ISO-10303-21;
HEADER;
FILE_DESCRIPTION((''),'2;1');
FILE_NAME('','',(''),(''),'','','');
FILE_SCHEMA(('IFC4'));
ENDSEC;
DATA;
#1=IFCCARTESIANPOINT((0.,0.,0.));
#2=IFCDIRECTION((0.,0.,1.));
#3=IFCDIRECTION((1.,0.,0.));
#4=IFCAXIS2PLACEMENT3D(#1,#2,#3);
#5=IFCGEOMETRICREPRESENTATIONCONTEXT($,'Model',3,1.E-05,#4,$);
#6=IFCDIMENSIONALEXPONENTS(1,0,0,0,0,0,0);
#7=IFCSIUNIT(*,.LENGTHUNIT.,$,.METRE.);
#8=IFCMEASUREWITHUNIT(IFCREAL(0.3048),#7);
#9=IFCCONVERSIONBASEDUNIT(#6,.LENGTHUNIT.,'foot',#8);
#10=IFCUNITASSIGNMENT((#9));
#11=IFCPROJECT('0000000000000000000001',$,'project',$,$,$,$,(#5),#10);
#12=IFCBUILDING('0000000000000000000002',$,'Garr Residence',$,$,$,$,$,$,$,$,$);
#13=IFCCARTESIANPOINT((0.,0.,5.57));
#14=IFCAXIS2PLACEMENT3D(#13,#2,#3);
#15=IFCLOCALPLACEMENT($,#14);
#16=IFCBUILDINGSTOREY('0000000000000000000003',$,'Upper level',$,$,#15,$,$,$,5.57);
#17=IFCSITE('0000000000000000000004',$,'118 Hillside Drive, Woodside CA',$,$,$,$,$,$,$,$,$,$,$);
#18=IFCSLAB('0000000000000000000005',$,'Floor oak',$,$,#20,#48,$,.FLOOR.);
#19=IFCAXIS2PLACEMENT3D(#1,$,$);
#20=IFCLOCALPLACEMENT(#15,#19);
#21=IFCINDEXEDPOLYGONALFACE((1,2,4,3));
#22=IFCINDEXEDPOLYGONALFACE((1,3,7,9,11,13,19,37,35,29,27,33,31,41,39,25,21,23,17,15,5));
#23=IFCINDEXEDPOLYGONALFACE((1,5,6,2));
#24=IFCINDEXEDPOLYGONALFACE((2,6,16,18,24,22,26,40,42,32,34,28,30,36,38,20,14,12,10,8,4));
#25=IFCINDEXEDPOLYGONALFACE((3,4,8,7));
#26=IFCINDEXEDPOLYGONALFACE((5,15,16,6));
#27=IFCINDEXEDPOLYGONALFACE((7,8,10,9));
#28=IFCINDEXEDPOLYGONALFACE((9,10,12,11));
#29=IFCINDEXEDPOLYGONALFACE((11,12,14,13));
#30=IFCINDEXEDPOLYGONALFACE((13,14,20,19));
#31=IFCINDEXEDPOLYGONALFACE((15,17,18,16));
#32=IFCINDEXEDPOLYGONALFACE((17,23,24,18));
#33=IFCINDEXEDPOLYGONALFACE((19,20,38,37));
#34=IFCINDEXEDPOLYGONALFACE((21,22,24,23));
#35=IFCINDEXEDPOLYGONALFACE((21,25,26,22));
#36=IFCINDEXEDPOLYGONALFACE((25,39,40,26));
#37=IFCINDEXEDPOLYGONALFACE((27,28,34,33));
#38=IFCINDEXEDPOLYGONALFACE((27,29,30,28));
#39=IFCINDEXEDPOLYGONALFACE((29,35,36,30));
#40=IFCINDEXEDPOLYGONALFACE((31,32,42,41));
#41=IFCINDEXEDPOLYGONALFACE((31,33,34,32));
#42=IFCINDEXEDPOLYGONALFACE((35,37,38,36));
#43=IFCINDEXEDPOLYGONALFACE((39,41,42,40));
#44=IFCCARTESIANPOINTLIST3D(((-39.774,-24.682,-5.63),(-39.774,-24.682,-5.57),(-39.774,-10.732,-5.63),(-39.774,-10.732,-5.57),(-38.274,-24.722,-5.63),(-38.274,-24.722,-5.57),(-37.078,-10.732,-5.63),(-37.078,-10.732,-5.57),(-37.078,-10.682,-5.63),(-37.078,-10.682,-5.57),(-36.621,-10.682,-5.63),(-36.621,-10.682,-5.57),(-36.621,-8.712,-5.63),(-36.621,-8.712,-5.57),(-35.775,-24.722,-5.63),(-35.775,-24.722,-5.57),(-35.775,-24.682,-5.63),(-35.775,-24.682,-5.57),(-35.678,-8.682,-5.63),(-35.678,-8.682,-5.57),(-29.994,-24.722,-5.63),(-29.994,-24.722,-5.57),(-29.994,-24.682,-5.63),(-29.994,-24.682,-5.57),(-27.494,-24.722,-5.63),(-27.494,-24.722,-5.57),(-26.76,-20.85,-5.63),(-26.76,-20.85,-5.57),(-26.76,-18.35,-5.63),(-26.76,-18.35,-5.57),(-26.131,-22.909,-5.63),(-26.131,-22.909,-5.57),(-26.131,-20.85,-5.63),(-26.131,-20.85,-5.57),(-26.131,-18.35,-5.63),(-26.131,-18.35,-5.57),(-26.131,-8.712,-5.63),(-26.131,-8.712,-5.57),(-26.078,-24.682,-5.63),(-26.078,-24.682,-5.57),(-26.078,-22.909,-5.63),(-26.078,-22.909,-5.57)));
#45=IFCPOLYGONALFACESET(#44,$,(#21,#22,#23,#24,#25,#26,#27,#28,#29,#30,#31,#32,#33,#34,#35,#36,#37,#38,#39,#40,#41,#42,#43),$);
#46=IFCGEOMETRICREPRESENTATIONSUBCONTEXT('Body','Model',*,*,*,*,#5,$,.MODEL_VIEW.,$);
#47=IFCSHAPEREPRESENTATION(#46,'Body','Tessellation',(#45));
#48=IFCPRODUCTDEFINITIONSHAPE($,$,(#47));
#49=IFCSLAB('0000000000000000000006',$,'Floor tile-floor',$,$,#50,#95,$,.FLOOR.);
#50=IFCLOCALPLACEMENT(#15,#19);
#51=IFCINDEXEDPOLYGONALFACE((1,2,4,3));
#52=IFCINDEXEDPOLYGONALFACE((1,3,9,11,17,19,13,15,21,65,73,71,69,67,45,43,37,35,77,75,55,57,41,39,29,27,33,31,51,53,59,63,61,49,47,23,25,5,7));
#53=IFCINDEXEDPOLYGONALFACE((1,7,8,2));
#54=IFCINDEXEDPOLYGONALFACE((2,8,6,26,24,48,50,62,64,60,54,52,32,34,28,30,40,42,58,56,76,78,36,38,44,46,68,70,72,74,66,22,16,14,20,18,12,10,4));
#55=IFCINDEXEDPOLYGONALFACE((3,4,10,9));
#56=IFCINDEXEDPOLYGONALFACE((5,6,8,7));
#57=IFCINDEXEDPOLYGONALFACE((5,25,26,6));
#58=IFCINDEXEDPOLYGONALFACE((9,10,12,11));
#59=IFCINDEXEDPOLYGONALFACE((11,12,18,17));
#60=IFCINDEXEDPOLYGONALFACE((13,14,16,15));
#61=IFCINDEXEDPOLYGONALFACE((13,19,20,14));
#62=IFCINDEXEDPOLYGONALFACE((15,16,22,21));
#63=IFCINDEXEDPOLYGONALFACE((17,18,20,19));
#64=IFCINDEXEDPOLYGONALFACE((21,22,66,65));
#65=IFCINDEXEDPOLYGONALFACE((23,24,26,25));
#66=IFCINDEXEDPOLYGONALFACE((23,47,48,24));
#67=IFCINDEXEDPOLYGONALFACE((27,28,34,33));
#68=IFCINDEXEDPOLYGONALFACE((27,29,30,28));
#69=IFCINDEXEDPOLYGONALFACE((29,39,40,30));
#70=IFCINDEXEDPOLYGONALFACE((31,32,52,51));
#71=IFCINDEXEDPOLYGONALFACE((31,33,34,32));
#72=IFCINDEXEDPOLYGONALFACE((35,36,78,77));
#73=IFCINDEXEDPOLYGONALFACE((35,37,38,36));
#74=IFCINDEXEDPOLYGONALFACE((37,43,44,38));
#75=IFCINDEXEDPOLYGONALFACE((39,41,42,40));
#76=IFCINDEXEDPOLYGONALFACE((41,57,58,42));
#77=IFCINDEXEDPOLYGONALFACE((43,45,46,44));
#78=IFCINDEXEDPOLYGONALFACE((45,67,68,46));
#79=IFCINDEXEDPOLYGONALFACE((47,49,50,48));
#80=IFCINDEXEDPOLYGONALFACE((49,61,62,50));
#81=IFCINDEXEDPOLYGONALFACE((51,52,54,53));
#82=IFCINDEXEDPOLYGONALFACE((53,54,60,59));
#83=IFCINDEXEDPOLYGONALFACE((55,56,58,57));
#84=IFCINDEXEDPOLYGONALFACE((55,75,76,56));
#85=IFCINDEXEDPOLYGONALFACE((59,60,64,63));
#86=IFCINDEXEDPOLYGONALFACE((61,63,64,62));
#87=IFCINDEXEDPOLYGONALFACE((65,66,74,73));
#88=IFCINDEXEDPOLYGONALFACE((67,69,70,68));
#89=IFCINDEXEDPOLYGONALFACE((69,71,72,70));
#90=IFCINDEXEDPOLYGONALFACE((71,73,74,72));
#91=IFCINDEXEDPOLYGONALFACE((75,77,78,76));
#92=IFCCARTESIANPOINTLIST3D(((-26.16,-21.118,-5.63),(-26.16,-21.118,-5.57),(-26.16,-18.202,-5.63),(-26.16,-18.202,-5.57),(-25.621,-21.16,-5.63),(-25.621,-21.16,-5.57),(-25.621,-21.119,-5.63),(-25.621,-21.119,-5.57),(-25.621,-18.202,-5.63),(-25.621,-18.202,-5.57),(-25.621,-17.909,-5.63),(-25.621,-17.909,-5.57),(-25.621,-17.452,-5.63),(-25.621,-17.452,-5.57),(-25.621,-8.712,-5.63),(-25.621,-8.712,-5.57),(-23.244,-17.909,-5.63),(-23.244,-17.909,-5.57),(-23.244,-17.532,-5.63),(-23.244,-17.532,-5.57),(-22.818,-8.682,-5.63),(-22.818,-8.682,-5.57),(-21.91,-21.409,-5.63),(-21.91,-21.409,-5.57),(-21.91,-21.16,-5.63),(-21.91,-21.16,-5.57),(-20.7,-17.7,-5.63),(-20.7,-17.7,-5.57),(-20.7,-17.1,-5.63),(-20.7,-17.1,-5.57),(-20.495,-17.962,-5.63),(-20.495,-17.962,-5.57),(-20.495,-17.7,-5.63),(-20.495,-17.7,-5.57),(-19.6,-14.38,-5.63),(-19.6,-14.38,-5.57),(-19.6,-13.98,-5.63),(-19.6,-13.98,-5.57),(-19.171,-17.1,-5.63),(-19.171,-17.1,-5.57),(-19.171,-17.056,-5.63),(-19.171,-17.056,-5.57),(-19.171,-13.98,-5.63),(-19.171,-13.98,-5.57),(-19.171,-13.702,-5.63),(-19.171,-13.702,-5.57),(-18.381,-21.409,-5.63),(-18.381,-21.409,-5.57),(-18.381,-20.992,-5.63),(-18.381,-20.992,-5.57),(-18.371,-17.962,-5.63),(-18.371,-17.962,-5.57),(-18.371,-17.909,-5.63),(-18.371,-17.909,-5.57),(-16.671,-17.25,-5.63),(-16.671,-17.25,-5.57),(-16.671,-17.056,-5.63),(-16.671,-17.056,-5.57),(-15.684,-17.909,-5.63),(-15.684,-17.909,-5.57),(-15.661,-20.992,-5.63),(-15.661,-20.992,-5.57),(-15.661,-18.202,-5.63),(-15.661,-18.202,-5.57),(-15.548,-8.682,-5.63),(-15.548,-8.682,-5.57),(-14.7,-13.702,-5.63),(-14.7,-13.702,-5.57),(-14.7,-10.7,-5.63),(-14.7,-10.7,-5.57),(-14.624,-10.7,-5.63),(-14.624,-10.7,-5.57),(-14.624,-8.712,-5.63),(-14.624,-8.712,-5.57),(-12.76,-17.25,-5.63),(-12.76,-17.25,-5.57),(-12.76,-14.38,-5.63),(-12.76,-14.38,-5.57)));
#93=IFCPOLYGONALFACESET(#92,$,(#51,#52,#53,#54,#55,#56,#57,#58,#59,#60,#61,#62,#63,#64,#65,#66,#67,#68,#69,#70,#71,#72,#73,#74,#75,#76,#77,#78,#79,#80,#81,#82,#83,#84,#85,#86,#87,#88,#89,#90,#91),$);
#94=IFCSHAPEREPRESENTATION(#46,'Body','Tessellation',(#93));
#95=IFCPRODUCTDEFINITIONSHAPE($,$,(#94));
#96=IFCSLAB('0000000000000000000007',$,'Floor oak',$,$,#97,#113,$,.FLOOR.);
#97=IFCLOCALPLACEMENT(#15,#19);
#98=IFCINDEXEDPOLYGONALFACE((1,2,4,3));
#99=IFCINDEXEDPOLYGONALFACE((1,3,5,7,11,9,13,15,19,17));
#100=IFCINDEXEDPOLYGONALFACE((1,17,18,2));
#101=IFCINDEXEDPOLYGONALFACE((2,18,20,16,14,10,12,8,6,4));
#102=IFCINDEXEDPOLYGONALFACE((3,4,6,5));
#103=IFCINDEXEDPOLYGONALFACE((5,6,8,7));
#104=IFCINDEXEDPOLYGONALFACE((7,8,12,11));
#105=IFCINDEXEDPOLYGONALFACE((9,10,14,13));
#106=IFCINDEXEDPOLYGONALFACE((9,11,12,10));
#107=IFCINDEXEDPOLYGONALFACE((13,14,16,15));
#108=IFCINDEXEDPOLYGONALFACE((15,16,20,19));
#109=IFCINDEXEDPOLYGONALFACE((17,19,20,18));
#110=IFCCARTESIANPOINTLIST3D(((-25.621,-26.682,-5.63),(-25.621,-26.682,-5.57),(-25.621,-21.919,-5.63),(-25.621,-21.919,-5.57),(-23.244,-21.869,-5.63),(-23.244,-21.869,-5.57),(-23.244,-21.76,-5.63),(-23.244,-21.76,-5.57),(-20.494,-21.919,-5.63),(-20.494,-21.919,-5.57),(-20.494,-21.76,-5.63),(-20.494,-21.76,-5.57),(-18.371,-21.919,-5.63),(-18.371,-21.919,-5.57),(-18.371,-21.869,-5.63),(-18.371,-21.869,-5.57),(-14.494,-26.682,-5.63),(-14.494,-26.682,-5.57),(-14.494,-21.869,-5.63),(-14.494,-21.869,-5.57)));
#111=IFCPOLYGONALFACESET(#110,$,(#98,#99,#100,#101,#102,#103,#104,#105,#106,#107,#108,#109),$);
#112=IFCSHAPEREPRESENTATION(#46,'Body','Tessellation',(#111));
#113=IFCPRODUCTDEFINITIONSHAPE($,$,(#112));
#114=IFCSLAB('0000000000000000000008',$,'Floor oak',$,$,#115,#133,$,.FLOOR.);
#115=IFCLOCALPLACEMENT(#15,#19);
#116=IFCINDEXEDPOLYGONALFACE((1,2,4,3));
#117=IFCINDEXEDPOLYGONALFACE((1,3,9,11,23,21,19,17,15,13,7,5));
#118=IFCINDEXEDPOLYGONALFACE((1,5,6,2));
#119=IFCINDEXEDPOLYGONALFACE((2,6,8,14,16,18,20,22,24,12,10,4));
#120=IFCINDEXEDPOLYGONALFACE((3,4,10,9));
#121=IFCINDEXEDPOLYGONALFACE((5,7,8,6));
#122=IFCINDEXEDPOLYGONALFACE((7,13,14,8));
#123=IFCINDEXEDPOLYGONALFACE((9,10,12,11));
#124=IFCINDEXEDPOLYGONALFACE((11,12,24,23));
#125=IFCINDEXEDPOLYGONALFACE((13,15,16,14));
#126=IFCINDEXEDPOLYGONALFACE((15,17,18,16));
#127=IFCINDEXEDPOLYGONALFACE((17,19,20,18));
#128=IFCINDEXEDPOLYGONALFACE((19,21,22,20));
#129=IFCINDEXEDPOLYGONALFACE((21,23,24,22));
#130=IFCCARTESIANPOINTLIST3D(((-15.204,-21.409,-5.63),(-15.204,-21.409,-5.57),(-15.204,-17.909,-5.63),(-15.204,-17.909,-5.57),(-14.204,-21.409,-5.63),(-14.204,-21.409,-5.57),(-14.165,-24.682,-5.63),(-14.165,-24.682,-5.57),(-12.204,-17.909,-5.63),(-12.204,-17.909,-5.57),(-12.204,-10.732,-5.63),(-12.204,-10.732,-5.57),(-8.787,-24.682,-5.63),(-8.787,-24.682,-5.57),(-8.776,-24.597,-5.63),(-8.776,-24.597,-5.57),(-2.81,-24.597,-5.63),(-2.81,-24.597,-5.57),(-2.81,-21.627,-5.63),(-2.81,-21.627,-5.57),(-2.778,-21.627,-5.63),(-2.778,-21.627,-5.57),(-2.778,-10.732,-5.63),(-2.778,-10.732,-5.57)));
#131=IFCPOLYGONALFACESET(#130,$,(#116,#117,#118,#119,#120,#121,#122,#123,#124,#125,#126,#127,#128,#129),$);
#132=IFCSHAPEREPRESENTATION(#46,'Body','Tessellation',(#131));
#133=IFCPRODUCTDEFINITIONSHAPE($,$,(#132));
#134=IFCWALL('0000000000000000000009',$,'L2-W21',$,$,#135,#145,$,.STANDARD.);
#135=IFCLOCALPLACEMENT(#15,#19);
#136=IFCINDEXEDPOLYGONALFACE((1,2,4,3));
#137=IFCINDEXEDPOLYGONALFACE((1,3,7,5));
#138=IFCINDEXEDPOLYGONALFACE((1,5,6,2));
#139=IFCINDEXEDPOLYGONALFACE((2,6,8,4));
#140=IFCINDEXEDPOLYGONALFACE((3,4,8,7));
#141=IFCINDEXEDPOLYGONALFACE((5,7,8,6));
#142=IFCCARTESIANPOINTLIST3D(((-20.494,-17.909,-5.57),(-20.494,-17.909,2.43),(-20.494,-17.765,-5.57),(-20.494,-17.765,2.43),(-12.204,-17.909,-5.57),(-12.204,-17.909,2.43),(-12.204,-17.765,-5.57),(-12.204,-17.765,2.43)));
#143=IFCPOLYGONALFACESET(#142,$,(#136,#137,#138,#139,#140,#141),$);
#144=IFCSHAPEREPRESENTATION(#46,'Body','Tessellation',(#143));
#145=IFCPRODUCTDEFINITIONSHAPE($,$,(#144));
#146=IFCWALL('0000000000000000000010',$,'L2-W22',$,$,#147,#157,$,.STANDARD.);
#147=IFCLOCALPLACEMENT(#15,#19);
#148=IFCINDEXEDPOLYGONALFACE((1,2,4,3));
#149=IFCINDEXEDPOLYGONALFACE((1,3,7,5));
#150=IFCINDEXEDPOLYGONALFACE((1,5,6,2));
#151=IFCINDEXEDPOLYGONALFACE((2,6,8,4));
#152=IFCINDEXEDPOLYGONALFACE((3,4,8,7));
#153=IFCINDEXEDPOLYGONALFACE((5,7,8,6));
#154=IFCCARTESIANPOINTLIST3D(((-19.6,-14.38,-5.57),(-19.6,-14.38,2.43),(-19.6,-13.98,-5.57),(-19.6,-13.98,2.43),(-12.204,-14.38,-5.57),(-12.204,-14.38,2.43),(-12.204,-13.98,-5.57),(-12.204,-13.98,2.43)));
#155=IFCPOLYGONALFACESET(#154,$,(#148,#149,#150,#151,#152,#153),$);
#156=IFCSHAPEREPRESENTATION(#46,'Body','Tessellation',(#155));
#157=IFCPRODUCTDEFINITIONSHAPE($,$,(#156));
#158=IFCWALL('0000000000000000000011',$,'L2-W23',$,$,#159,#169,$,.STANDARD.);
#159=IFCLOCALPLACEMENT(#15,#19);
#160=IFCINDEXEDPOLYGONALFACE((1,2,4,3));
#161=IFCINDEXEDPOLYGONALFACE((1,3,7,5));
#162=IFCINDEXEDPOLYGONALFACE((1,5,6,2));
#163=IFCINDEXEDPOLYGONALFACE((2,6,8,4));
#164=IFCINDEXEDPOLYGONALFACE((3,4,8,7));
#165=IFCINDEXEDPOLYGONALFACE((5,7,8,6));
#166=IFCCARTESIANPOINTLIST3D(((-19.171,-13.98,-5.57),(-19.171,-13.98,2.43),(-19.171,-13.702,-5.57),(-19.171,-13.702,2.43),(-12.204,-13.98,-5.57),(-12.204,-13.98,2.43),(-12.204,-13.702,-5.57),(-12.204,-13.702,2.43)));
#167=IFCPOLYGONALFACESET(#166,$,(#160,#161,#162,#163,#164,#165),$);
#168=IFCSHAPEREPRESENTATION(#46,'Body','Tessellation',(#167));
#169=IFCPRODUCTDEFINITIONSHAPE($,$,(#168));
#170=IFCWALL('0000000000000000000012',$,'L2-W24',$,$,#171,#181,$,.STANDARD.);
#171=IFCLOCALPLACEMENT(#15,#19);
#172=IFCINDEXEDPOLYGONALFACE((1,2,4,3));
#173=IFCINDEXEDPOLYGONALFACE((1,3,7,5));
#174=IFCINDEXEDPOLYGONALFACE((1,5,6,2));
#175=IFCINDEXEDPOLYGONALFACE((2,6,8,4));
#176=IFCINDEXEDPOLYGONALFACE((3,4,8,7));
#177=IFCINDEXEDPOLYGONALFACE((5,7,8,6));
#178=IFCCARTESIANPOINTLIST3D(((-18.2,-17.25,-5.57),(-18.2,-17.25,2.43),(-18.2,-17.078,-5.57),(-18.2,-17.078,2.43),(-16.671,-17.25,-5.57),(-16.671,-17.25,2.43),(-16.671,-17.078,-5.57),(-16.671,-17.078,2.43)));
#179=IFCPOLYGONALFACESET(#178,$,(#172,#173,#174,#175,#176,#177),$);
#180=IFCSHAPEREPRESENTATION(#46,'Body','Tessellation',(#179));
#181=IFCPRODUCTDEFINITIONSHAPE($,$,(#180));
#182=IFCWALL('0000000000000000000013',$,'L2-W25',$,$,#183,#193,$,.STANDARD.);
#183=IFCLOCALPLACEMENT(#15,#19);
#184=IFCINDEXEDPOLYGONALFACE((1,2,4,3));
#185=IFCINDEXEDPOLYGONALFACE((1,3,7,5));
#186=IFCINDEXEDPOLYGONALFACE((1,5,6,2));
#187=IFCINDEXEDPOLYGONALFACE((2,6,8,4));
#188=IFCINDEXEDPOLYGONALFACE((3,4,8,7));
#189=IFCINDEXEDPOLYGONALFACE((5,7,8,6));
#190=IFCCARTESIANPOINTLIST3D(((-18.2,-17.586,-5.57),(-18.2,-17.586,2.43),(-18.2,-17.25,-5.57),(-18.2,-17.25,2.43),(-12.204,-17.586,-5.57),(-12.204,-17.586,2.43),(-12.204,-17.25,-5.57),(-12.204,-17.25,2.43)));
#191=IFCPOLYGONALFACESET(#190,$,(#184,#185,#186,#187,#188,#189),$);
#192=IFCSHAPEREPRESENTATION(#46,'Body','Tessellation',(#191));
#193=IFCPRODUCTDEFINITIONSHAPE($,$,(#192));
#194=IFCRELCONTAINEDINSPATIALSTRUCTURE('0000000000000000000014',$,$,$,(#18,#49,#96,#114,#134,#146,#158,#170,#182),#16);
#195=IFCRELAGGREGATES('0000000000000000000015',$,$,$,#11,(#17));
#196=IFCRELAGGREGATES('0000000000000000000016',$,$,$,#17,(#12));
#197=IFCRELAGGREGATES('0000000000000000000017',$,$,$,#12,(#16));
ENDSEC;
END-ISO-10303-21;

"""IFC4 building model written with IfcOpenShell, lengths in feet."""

from ifc_helpers import new_model, entity, si_unit, converted_unit, frame, origin, origin_with_axes, place, context, subcontext, project, spatial, polyline, outline, extrude, element, save


model = new_model("IFC4")

# Units and contexts
model_context = context("Model", 3, precision=1e-05, world=origin_with_axes())
body_context = subcontext(model_context, "Body", "Model", "MODEL_VIEW")
ifc_project = project(units=[converted_unit("LENGTHUNIT", "foot", entity("IfcReal", 0.3048), si_unit("LENGTHUNIT", "METRE"), dimensions=[1, 0, 0, 0, 0, 0, 0])], contexts=[model_context])

# Site, building, storey
site = spatial("IfcSite", under=ifc_project, Name="118 Hillside Drive, Woodside CA")
building = spatial("IfcBuilding", under=site, Name="Garr Residence")
storey_placement = place(None, frame((0.0, 0.0, 5.57), z_axis=(0.0, 0.0, 1.0), x_axis=(1.0, 0.0, 0.0)))
storey = spatial("IfcBuildingStorey", under=building, at=storey_placement, Name="Upper level", Elevation=5.57)

# Slabs
slab_1_placement = place(storey_placement, frame((0.0, 0.0, -5.63), z_axis=(0.0, 0.0, 1.0), x_axis=(1.0, 0.0, 0.0)))
element("IfcSlab", 1, at=slab_1_placement, inside=storey, Name="Floor oak", PredefinedType="FLOOR", context=body_context, shape_type="SweptSolid", body=[
    extrude(outline(polyline([(-39.774, -10.732), (-37.078, -10.732), (-37.078, -10.682), (-36.621, -10.682), (-36.621, -8.712), (-35.678, -8.682), (-26.131, -8.712), (-26.131, -18.35), (-26.76, -18.35), (-26.76, -20.85), (-26.131, -20.85), (-26.131, -22.909), (-26.078, -22.909), (-26.078, -24.682), (-27.494, -24.722), (-29.994, -24.722), (-29.994, -24.682), (-35.775, -24.682), (-35.775, -24.722), (-38.274, -24.722), (-39.774, -24.682), (-39.774, -10.732)])), origin(), (0.0, 0.0, 1.0), 0.06),
])
slab_2_placement = place(storey_placement, frame((0.0, 0.0, -5.63), z_axis=(0.0, 0.0, 1.0), x_axis=(1.0, 0.0, 0.0)))
element("IfcSlab", 2, at=slab_2_placement, inside=storey, Name="Floor tile-floor", PredefinedType="FLOOR", context=body_context, shape_type="SweptSolid", body=[
    extrude(outline(polyline([(-26.16, -18.202), (-25.621, -18.202), (-25.621, -17.909), (-23.244, -17.909), (-23.244, -17.532), (-25.621, -17.452), (-25.621, -8.712), (-22.818, -8.682), (-15.548, -8.682), (-14.624, -8.712), (-14.624, -10.7), (-14.7, -10.7), (-14.7, -13.702), (-19.171, -13.702), (-19.171, -13.98), (-19.6, -13.98), (-19.6, -14.38), (-12.76, -14.38), (-12.76, -17.25), (-16.671, -17.25), (-16.671, -17.056), (-19.171, -17.056), (-19.171, -17.1), (-20.7, -17.1), (-20.7, -17.7), (-20.495, -17.7), (-20.495, -17.962), (-18.371, -17.962), (-18.371, -17.909), (-15.684, -17.909), (-15.661, -18.202), (-15.661, -20.992), (-18.381, -20.992), (-18.381, -21.409), (-21.91, -21.409), (-21.91, -21.16), (-25.621, -21.16), (-25.621, -21.119), (-26.16, -21.118), (-26.16, -18.202)])), origin(), (0.0, 0.0, 1.0), 0.06),
])
slab_3_placement = place(storey_placement, frame((0.0, 0.0, -5.63), z_axis=(0.0, 0.0, 1.0), x_axis=(1.0, 0.0, 0.0)))
element("IfcSlab", 3, at=slab_3_placement, inside=storey, Name="Floor oak", PredefinedType="FLOOR", context=body_context, shape_type="SweptSolid", body=[
    extrude(outline(polyline([(-23.244, -21.76), (-20.494, -21.76), (-20.494, -21.919), (-18.371, -21.919), (-18.371, -21.869), (-14.494, -21.869), (-14.494, -26.682), (-25.621, -26.682), (-25.621, -21.919), (-23.244, -21.869), (-23.244, -21.76)])), origin(), (0.0, 0.0, 1.0), 0.06),
])
slab_4_placement = place(storey_placement, frame((0.0, 0.0, -5.63), z_axis=(0.0, 0.0, 1.0), x_axis=(1.0, 0.0, 0.0)))
element("IfcSlab", 4, at=slab_4_placement, inside=storey, Name="Floor oak", PredefinedType="FLOOR", context=body_context, shape_type="SweptSolid", body=[
    extrude(outline(polyline([(-15.204, -21.409), (-15.204, -17.909), (-12.204, -17.909), (-12.204, -10.732), (-2.778, -10.732), (-2.778, -21.627), (-2.81, -21.627), (-2.81, -24.597), (-8.776, -24.597), (-8.787, -24.682), (-14.165, -24.682), (-14.204, -21.409), (-15.204, -21.409)])), origin(), (0.0, 0.0, 1.0), 0.06),
])

# Walls
wall_1_placement = place(storey_placement, frame((0.0, 0.0, -5.57), z_axis=(0.0, 0.0, 1.0), x_axis=(1.0, 0.0, 0.0)))
element("IfcWall", 5, at=wall_1_placement, inside=storey, Name="L2-W21", PredefinedType="STANDARD", context=body_context, shape_type="SweptSolid", body=[
    extrude(outline(polyline([(-12.204, -17.909), (-12.204, -17.765), (-20.494, -17.765), (-20.494, -17.909), (-12.204, -17.909)])), origin(), (0.0, 0.0, 1.0), 8.0),
])
wall_2_placement = place(storey_placement, frame((0.0, 0.0, -5.57), z_axis=(0.0, 0.0, 1.0), x_axis=(1.0, 0.0, 0.0)))
element("IfcWall", 6, at=wall_2_placement, inside=storey, Name="L2-W22", PredefinedType="STANDARD", context=body_context, shape_type="SweptSolid", body=[
    extrude(outline(polyline([(-12.204, -14.38), (-12.204, -13.98), (-19.6, -13.98), (-19.6, -14.38), (-12.204, -14.38)])), origin(), (0.0, 0.0, 1.0), 8.0),
])
wall_3_placement = place(storey_placement, frame((0.0, 0.0, -5.57), z_axis=(0.0, 0.0, 1.0), x_axis=(1.0, 0.0, 0.0)))
element("IfcWall", 7, at=wall_3_placement, inside=storey, Name="L2-W23", PredefinedType="STANDARD", context=body_context, shape_type="SweptSolid", body=[
    extrude(outline(polyline([(-12.204, -13.98), (-12.204, -13.702), (-19.171, -13.702), (-19.171, -13.98), (-12.204, -13.98)])), origin(), (0.0, 0.0, 1.0), 8.0),
])
wall_4_placement = place(storey_placement, frame((0.0, 0.0, -5.57), z_axis=(0.0, 0.0, 1.0), x_axis=(1.0, 0.0, 0.0)))
element("IfcWall", 8, at=wall_4_placement, inside=storey, Name="L2-W24", PredefinedType="STANDARD", context=body_context, shape_type="SweptSolid", body=[
    extrude(outline(polyline([(-16.671, -17.25), (-16.671, -17.078), (-18.2, -17.078), (-18.2, -17.25), (-16.671, -17.25)])), origin(), (0.0, 0.0, 1.0), 8.0),
])
wall_5_placement = place(storey_placement, frame((0.0, 0.0, -5.57), z_axis=(0.0, 0.0, 1.0), x_axis=(1.0, 0.0, 0.0)))
element("IfcWall", 9, at=wall_5_placement, inside=storey, Name="L2-W25", PredefinedType="STANDARD", context=body_context, shape_type="SweptSolid", body=[
    extrude(outline(polyline([(-12.204, -17.586), (-12.204, -17.25), (-18.2, -17.25), (-18.2, -17.586), (-12.204, -17.586)])), origin(), (0.0, 0.0, 1.0), 8.0),
])

save(model, "model.ifc")
